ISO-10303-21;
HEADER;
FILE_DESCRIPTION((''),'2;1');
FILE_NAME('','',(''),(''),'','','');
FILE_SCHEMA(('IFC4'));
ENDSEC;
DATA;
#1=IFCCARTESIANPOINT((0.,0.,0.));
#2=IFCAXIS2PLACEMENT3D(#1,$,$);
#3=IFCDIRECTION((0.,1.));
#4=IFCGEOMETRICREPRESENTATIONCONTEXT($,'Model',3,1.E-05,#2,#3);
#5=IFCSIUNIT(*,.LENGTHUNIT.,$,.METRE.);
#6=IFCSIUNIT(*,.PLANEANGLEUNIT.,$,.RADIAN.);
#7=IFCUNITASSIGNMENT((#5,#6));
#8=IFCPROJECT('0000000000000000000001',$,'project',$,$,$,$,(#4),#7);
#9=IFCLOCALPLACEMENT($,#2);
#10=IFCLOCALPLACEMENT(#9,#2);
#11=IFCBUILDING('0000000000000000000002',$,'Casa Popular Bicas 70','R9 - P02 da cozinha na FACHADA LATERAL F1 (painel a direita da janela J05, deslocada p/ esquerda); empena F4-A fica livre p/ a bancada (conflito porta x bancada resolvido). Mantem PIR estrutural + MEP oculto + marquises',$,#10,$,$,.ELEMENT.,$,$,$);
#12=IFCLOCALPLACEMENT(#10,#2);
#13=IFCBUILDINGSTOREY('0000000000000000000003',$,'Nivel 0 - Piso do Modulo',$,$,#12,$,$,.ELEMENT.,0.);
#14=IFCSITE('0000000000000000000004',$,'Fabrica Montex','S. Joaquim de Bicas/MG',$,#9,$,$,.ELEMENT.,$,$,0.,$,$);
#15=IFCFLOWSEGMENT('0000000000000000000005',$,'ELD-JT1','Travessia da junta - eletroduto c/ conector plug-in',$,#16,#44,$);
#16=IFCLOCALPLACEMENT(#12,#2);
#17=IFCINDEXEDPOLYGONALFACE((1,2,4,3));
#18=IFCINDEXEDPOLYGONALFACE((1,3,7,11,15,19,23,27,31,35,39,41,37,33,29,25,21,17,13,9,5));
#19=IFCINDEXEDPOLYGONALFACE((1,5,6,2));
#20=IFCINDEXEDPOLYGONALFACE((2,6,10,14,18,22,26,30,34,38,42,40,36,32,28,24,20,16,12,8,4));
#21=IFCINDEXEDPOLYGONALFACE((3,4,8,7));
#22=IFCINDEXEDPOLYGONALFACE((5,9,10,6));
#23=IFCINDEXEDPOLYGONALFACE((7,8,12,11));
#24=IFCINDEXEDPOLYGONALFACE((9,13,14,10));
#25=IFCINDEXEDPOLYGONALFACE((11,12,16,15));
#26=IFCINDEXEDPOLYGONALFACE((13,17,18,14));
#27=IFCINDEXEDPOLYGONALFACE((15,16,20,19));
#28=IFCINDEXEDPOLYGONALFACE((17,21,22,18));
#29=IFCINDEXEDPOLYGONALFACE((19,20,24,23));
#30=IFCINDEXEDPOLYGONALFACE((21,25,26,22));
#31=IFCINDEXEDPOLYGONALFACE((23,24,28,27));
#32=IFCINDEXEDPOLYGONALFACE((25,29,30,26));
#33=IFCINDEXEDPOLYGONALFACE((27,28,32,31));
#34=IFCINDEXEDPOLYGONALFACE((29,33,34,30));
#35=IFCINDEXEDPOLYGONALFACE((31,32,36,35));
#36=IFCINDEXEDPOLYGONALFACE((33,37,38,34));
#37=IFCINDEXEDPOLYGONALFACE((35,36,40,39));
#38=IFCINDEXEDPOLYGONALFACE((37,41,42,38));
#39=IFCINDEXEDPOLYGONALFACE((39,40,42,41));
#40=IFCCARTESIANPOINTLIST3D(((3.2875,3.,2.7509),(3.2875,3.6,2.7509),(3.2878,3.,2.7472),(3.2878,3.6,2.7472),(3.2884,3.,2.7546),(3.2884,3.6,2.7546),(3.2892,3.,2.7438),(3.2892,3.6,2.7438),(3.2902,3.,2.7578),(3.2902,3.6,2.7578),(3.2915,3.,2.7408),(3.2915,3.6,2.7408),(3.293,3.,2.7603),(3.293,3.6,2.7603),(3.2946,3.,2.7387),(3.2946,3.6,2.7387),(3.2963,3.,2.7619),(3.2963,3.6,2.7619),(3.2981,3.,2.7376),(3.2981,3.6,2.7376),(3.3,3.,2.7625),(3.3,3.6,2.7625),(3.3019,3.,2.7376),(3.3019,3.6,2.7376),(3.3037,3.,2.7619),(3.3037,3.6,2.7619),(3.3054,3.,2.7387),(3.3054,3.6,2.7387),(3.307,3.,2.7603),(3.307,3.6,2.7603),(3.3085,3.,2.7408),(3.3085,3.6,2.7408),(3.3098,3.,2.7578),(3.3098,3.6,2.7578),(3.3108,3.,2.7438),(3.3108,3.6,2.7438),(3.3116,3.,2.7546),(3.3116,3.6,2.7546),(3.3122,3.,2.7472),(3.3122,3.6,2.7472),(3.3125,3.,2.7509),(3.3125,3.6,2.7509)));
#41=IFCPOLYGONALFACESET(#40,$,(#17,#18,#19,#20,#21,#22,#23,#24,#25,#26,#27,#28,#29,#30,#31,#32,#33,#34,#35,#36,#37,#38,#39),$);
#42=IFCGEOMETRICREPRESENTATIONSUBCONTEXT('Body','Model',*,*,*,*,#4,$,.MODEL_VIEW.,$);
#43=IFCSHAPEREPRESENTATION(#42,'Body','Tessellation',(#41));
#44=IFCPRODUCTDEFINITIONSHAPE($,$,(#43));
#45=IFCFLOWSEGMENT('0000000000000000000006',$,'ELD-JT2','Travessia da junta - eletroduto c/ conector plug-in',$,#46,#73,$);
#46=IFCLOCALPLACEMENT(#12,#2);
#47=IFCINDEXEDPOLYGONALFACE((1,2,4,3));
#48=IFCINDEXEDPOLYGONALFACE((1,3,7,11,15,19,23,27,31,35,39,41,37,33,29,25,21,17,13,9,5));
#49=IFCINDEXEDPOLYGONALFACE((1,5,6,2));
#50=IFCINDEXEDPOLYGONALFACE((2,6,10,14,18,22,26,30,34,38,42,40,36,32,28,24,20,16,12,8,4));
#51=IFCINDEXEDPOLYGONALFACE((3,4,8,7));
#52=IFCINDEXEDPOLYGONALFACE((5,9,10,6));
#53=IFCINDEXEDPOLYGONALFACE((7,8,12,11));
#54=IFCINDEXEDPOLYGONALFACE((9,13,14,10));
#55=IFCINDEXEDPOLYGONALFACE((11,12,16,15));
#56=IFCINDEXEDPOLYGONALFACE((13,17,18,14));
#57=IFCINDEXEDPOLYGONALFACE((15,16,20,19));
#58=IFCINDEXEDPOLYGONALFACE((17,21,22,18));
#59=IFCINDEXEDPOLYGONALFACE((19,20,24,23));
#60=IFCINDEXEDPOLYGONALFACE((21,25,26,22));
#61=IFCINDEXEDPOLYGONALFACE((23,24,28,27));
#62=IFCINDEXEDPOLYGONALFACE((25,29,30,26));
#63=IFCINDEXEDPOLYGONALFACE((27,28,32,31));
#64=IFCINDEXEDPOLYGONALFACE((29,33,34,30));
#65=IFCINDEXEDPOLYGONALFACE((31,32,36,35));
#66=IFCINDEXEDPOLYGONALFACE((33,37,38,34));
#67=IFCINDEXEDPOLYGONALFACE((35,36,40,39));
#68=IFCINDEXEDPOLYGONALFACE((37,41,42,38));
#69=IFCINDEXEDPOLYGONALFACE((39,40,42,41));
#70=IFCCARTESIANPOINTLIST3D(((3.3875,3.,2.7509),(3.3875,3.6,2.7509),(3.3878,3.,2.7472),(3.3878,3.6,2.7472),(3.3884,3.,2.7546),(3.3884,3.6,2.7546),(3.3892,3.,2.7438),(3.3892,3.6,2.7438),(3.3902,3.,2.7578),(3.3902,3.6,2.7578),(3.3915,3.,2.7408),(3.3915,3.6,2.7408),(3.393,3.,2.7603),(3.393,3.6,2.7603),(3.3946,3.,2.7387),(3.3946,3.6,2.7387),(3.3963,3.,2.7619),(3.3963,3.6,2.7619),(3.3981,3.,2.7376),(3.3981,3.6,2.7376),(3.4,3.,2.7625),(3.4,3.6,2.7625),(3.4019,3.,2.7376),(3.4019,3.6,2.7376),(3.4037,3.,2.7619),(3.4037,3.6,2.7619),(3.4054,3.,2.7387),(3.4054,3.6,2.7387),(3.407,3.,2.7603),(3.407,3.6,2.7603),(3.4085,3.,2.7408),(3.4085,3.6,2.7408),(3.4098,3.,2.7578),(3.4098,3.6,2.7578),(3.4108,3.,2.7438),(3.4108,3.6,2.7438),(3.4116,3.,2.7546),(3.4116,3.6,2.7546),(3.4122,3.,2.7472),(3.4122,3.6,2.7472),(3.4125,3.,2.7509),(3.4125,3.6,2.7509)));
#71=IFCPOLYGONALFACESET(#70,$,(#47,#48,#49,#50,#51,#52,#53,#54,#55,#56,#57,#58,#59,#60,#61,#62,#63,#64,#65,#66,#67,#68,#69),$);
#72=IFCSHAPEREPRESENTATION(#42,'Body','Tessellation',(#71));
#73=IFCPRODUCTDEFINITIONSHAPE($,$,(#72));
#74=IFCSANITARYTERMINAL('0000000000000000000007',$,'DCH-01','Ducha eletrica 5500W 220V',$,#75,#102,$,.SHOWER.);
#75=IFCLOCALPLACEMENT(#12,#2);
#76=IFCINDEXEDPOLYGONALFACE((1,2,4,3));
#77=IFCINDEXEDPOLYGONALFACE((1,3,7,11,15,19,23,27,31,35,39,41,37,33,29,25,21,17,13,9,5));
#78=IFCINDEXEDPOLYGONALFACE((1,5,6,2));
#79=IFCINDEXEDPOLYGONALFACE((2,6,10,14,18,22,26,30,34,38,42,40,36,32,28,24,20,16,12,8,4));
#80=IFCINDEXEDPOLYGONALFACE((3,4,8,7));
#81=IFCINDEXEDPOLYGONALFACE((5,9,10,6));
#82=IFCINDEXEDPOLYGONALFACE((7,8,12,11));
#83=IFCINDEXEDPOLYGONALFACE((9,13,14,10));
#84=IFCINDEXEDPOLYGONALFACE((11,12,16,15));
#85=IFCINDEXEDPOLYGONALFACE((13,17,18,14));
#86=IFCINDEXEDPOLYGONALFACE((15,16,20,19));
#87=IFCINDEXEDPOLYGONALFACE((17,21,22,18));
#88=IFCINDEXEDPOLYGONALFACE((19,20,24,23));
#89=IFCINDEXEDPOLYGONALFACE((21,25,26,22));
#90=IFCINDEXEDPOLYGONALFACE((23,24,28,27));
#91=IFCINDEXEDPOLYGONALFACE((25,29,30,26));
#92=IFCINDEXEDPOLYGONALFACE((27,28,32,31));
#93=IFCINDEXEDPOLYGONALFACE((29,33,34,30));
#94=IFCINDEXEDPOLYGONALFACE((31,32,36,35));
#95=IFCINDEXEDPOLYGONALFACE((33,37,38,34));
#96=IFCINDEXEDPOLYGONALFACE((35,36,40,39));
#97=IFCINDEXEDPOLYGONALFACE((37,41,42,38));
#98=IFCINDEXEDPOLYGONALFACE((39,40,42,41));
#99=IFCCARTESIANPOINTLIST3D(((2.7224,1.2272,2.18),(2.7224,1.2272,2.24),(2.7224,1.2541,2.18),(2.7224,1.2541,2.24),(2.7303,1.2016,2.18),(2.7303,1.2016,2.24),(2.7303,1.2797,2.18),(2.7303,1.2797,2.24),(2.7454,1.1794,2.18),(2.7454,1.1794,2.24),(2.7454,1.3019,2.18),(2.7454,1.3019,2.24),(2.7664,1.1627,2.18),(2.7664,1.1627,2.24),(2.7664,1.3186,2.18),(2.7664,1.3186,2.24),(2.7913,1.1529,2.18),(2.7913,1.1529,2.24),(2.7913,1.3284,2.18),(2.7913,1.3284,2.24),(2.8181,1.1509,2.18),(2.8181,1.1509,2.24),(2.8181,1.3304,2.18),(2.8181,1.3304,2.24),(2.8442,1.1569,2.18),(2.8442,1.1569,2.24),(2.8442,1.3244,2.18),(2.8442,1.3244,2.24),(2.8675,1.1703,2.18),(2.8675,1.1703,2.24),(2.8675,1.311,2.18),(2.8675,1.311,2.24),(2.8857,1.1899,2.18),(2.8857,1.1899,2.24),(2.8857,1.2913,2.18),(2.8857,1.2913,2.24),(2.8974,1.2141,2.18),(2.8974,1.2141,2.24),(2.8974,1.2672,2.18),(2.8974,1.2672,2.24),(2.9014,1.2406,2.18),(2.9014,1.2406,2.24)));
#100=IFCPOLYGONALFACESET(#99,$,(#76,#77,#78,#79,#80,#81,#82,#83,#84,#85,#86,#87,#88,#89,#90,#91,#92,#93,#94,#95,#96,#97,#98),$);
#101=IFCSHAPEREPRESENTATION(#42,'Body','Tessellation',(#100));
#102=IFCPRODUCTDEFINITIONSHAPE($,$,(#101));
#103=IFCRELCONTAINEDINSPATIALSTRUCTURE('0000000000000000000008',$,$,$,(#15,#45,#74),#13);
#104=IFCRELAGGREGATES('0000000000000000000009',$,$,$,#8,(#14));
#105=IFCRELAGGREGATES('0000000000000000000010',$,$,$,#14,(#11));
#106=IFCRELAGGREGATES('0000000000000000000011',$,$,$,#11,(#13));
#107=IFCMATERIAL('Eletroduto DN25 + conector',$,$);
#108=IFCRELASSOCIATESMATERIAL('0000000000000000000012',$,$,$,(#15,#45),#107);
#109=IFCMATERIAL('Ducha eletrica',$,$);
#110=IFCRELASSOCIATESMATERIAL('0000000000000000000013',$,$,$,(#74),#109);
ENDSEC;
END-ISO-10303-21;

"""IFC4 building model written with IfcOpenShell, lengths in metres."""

from ifc_helpers import new_model, si_unit, direction, frame, origin, origin_2d, place, context, subcontext, project, spatial, circle, extrude, material, element, save


model = new_model("IFC4")

# Units and contexts
model_context = context("Model", 3, precision=1e-05, world=origin(), true_north=direction((0.0, 1.0)))
body_context = subcontext(model_context, "Body", "Model", "MODEL_VIEW")
ifc_project = project(units=[si_unit("LENGTHUNIT", "METRE"), si_unit("PLANEANGLEUNIT", "RADIAN")], contexts=[model_context])

# Site, building, storey
site_placement = place(None, origin())
site = spatial("IfcSite", under=ifc_project, at=site_placement, Name="Fabrica Montex", Description="S. Joaquim de Bicas/MG", CompositionType="ELEMENT", RefElevation=0.0)
building_placement = place(site_placement, origin())
building = spatial("IfcBuilding", under=site, at=building_placement, Name="Casa Popular Bicas 70", Description="R9 - P02 da cozinha na FACHADA LATERAL F1 (painel a direita da janela J05, deslocada p/ esquerda); empena F4-A fica livre p/ a bancada (conflito porta x bancada resolvido). Mantem PIR estrutural + MEP oculto + marquises", CompositionType="ELEMENT")
storey_placement = place(building_placement, origin())
storey = spatial("IfcBuildingStorey", under=building, at=storey_placement, Name="Nivel 0 - Piso do Modulo", CompositionType="ELEMENT", Elevation=0.0)

# Flow segments
ifc_material_1 = material(Name="Eletroduto DN25 + conector")
for number, where, z_axis, x_axis, name in (
    (1, (3.3, 3.0, 2.75), (0.0, 1.0, 0.0), (0.0, 0.0, 1.0), "ELD-JT1"),
    (2, (3.4, 3.0, 2.75), (0.0, 1.0, 0.0), (0.0, 0.0, 1.0), "ELD-JT2"),
):
    element("IfcFlowSegment", number, at=place(storey_placement, frame(where, z_axis=z_axis, x_axis=x_axis)), inside=storey, material=ifc_material_1, Name=name, Description="Travessia da junta - eletroduto c/ conector plug-in", context=body_context, shape_type="SweptSolid", body=[
        extrude(circle(Radius=0.0125, at=origin_2d()), origin(), (0.0, 0.0, 1.0), 0.6),
    ])

# Sanitary terminal
ifc_material_2 = material(Name="Ducha eletrica")
sanitary_terminal_placement = place(storey_placement, frame((2.8114, 1.2406, 2.18)))
element("IfcSanitaryTerminal", 3, at=sanitary_terminal_placement, inside=storey, material=ifc_material_2, Name="DCH-01", Description="Ducha eletrica 5500W 220V", PredefinedType="SHOWER", context=body_context, shape_type="SweptSolid", body=[
    extrude(circle(Radius=0.09, at=origin_2d()), origin(), (0.0, 0.0, 1.0), 0.06),
])

save(model, "model.ifc")
